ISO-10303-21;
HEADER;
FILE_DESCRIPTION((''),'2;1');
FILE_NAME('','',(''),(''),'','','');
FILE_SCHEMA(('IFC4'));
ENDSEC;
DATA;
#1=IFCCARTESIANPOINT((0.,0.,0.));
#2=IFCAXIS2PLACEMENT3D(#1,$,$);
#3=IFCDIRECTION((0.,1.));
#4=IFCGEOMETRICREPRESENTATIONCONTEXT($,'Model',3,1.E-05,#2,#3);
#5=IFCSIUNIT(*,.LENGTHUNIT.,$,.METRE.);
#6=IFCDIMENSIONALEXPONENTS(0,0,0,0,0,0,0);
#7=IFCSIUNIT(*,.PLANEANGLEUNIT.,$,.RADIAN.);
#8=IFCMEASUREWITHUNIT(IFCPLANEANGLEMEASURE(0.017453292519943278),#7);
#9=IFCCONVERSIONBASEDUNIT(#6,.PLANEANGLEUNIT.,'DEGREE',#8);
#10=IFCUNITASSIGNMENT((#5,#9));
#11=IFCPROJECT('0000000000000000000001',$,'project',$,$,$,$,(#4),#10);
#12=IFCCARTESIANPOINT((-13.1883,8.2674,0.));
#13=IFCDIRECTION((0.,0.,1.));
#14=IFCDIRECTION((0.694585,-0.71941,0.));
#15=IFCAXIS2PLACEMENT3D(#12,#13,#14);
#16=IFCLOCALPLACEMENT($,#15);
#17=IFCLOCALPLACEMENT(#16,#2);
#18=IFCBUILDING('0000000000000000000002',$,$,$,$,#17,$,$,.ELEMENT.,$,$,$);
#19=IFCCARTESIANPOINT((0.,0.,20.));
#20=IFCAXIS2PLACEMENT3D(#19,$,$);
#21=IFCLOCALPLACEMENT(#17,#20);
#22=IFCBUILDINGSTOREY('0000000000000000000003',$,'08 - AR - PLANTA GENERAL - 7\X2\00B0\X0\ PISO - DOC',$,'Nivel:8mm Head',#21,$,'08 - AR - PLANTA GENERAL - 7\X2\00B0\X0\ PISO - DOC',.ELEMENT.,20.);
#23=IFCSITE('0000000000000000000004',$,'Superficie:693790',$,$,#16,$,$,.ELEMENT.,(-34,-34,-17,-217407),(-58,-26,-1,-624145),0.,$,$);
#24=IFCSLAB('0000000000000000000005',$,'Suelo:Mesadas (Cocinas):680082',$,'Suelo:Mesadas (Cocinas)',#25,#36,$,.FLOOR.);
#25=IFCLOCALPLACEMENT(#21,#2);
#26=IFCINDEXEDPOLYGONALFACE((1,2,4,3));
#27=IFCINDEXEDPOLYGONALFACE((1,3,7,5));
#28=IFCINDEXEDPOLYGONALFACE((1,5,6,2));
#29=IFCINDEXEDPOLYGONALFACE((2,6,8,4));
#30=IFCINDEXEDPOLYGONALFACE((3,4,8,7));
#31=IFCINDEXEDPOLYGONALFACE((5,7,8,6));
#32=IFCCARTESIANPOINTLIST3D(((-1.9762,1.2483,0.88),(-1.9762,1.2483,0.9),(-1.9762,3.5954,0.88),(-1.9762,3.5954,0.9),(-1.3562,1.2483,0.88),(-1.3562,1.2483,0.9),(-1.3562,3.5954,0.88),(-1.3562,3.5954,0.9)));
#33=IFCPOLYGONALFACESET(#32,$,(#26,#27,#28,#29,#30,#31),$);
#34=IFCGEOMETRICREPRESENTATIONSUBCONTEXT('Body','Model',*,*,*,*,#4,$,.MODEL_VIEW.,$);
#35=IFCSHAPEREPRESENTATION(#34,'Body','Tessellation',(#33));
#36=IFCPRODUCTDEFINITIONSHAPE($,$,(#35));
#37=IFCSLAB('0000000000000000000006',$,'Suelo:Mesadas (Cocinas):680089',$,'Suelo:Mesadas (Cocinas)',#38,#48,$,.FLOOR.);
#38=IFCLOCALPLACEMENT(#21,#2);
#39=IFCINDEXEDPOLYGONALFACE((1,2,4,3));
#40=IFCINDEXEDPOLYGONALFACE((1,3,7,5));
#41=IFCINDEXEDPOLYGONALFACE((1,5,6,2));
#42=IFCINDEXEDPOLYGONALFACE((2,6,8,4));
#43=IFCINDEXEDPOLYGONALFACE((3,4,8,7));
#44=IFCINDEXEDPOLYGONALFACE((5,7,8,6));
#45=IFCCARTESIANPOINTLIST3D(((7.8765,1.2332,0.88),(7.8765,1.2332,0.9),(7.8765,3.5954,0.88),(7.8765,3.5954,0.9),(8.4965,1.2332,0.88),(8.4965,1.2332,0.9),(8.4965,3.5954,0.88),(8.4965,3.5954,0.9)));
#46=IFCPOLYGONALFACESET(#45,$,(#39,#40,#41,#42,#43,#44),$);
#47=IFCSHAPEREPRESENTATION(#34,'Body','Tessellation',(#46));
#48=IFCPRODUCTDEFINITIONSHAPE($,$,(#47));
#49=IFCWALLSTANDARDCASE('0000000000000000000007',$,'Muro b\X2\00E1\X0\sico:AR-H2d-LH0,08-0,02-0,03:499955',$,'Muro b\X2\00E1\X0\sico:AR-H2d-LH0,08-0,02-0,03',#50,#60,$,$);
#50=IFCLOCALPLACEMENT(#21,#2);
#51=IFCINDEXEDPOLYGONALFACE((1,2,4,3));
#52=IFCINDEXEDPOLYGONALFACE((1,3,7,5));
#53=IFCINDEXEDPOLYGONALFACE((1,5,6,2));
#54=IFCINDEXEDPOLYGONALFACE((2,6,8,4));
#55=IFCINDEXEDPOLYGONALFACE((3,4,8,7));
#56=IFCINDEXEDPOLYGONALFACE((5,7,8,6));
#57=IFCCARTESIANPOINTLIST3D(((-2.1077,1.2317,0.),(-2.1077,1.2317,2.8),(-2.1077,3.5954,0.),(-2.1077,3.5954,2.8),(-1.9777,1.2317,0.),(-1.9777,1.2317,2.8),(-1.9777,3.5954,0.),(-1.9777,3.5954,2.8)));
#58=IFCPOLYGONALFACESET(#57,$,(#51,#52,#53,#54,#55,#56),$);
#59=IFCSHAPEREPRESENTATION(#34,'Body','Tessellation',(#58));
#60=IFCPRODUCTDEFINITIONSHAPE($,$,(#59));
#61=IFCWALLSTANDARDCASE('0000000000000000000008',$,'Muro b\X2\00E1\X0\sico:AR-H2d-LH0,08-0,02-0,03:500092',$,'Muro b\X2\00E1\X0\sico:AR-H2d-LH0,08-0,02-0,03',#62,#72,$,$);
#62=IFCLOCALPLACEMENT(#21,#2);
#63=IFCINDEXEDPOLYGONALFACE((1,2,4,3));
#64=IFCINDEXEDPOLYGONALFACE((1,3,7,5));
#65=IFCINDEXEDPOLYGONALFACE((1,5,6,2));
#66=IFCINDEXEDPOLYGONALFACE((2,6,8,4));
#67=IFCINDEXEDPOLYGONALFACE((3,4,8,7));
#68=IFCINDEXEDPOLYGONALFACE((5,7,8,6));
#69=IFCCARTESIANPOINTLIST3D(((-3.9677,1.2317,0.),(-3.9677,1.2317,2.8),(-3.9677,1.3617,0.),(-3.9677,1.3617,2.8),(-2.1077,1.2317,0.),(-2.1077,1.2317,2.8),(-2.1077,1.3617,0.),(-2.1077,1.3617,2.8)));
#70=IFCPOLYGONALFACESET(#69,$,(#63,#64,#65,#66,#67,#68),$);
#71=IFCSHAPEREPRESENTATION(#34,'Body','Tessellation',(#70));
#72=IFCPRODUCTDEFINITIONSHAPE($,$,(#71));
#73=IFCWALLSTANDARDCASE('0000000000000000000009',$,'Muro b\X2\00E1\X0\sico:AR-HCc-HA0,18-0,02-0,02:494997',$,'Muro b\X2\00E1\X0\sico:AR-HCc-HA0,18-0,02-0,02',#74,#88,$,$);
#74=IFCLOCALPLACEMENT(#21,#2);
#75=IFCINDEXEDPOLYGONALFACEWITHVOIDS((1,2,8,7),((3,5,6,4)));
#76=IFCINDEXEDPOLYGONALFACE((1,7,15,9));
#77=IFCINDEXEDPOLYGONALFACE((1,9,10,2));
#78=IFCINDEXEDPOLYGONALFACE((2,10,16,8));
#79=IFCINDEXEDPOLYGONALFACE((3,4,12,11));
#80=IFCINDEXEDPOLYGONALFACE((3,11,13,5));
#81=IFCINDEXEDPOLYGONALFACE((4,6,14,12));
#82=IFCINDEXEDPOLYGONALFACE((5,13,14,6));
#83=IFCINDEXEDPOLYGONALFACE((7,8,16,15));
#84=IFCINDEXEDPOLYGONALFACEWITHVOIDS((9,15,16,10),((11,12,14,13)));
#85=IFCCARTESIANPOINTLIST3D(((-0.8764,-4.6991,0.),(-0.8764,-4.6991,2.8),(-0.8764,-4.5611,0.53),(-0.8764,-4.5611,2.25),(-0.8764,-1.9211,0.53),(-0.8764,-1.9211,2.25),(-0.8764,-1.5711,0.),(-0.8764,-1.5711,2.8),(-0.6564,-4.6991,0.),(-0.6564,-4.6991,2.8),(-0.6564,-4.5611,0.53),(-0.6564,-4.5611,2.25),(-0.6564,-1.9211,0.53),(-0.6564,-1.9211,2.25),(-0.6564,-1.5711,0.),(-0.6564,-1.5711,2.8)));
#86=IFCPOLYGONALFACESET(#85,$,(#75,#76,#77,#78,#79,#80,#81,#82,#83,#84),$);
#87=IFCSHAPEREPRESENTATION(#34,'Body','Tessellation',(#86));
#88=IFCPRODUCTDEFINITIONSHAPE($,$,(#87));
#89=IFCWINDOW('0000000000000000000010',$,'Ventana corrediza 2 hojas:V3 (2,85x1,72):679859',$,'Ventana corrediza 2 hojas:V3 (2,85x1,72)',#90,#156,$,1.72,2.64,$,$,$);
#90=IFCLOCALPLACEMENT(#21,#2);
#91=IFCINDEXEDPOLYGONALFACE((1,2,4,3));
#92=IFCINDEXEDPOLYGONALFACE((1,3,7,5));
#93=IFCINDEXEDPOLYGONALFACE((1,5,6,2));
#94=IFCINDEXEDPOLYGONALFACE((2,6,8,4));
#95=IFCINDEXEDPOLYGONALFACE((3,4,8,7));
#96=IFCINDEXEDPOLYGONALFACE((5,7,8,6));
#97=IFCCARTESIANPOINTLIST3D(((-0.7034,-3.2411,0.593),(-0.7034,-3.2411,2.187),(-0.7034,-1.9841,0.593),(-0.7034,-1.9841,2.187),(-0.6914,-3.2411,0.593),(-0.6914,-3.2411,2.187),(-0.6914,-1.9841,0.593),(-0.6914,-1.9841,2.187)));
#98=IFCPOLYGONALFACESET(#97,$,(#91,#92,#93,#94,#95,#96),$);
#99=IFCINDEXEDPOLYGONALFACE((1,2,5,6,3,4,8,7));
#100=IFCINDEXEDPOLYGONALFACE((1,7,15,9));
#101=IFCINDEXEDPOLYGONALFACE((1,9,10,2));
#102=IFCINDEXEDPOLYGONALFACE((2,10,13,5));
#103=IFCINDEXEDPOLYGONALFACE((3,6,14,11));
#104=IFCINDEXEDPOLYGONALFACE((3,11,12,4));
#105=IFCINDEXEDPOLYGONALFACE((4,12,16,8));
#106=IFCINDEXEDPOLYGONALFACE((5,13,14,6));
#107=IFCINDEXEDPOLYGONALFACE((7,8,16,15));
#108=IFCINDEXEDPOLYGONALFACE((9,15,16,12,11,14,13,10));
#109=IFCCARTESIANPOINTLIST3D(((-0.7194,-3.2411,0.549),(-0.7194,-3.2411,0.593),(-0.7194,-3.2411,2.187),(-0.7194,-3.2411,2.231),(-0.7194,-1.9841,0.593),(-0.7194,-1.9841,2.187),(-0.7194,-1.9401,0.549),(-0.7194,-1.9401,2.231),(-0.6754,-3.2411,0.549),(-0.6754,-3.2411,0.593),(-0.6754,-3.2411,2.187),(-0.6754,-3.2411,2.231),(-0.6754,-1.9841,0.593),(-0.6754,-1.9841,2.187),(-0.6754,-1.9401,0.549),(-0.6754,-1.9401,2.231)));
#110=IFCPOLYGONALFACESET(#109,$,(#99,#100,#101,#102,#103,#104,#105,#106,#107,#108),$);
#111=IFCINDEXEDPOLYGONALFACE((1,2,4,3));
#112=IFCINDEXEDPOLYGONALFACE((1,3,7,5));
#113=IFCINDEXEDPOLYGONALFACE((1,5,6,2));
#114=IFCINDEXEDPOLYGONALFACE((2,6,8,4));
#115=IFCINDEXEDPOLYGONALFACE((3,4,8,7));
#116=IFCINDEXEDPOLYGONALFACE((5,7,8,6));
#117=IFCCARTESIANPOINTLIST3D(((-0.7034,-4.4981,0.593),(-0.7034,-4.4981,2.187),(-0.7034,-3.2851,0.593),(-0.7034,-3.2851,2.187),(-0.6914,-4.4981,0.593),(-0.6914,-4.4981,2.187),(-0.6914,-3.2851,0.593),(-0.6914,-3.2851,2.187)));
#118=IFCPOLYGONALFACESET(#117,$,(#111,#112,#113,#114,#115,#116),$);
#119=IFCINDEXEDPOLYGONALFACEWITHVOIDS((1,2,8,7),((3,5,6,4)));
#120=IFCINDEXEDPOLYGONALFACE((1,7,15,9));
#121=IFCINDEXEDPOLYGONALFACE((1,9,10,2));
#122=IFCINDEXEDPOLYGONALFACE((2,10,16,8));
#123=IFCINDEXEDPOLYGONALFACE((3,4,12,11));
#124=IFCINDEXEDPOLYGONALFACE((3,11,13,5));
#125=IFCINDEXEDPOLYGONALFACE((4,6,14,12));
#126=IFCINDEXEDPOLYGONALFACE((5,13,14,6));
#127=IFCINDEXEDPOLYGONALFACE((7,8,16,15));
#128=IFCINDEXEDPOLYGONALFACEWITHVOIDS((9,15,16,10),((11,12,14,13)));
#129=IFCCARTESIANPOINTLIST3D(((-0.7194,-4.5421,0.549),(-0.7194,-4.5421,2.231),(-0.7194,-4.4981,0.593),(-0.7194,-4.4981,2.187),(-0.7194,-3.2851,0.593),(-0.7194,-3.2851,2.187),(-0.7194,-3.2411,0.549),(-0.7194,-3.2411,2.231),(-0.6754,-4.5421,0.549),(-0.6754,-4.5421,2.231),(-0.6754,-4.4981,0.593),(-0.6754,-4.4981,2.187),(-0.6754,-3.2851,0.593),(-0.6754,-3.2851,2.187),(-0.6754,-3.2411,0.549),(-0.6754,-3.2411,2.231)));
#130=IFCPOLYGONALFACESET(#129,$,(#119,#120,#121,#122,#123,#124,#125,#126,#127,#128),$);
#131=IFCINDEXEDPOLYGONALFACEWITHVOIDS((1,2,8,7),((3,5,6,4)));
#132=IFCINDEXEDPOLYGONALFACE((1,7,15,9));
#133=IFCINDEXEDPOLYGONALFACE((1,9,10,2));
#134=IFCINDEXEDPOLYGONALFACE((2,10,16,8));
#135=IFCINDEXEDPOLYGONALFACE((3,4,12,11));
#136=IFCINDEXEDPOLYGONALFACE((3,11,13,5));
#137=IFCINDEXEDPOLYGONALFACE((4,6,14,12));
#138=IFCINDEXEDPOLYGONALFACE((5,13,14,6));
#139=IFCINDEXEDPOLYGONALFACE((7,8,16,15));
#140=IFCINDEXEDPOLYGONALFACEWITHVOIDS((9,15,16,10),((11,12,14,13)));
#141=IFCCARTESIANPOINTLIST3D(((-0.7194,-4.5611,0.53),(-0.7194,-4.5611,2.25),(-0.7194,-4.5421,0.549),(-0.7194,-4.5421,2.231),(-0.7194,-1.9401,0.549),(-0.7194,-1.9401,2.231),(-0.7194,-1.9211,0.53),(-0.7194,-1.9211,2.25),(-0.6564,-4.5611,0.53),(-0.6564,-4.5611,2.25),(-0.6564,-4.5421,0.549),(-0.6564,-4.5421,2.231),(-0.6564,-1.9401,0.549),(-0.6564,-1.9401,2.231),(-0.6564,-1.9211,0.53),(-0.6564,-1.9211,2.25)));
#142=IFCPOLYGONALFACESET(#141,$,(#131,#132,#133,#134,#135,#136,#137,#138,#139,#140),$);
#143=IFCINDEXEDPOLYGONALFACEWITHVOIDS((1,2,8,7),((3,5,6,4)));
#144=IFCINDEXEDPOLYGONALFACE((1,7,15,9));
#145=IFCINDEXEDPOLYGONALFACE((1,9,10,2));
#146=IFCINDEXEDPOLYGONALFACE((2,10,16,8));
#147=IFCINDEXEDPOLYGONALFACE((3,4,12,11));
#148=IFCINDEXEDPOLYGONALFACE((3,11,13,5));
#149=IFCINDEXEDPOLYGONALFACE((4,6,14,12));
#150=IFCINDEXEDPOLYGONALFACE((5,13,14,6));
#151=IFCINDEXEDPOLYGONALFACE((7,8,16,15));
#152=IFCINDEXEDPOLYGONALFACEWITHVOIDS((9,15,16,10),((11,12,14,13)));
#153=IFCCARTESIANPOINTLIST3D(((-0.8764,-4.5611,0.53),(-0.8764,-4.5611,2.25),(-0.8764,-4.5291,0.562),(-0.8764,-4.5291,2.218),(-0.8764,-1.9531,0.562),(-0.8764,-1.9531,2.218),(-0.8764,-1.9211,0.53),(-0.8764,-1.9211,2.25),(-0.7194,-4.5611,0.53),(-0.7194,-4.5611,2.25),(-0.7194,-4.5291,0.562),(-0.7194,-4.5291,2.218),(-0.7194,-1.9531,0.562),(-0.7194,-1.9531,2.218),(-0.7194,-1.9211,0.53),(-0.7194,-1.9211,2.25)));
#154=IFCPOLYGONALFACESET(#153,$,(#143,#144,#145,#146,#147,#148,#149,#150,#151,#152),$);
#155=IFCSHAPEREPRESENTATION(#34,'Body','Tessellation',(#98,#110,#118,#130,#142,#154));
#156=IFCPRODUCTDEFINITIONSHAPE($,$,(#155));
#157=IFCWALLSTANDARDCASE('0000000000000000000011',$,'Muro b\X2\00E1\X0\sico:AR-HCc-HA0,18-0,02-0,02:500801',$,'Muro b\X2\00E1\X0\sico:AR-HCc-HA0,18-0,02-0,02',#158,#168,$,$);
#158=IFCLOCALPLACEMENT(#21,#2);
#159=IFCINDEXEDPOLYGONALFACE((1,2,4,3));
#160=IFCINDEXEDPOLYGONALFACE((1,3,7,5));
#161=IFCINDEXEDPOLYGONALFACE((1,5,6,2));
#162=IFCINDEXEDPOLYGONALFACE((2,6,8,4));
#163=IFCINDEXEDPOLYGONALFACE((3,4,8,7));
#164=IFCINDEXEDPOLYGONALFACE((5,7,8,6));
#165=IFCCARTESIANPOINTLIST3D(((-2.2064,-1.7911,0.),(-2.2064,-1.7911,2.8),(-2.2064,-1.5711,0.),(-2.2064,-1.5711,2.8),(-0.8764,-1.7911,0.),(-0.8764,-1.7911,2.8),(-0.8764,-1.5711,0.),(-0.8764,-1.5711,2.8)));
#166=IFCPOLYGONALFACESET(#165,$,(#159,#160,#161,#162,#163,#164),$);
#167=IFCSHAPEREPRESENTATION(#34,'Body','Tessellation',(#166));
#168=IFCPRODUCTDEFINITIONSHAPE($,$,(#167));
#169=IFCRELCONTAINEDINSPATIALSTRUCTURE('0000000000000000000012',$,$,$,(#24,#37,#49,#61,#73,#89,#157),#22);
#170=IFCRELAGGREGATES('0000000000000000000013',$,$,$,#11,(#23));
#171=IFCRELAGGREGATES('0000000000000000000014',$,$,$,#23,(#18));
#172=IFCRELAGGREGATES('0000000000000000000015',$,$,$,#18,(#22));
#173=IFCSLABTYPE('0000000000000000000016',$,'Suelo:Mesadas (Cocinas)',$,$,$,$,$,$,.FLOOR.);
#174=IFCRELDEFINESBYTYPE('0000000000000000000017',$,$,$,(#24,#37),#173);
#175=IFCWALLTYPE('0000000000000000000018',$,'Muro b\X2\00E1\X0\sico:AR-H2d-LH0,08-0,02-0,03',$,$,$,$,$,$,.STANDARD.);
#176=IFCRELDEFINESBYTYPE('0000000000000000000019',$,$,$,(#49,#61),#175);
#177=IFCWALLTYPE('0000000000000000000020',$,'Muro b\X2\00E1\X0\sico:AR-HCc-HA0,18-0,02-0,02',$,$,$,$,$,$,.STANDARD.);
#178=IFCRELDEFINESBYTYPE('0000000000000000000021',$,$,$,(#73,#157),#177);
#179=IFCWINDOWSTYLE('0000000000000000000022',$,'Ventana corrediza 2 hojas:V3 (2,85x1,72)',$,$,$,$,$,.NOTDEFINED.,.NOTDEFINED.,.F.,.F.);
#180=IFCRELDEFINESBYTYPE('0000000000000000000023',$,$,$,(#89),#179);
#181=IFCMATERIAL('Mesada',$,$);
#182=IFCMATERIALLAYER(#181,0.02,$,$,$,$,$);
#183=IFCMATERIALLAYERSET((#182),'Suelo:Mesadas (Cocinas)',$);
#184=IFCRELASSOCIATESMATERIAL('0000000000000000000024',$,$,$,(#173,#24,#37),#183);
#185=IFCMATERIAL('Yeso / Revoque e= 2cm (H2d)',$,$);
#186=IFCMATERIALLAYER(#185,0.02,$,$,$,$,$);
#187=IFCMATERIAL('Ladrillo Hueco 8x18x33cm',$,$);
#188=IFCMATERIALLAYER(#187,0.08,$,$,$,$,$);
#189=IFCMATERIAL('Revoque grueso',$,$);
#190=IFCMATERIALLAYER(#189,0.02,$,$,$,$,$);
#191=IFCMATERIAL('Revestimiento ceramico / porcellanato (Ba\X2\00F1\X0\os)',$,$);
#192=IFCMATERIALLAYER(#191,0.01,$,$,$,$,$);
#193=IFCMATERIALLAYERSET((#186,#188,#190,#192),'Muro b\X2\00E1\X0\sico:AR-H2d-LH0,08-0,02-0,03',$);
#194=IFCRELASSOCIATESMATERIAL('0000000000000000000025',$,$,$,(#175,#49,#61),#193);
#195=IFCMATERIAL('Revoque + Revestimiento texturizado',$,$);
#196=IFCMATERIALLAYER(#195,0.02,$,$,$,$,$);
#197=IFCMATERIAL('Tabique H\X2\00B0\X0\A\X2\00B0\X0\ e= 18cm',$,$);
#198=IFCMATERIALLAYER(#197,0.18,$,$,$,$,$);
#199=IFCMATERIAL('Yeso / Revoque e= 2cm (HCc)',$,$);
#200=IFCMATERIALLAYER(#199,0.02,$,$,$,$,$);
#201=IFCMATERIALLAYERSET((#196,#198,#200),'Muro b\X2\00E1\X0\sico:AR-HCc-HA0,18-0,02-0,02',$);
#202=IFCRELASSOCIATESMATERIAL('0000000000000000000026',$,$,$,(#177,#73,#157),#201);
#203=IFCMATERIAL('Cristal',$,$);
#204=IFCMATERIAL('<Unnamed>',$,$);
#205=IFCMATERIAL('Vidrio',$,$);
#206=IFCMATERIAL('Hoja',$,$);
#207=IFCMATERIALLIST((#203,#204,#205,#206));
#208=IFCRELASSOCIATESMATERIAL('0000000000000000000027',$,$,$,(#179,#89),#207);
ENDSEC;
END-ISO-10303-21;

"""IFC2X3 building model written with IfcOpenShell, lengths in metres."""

from ifc_helpers import new_model, entity, si_unit, converted_unit, direction, frame, frame_2d, origin, origin_2d_with_axis, place, context, subcontext, project, spatial, polyline, rectangle, outline, extrude, source, transform, mapped, material, material_list, layer, layer_set, layer_usage, type_object, type_shapes, element, fill, save


model = new_model("IFC2X3")

# Units and contexts
model_context = context("Model", 3, precision=1e-05, world=origin(), true_north=direction((0.0, 1.0)))
body_context = subcontext(model_context, "Body", "Model", "MODEL_VIEW")
ifc_project = project(units=[si_unit("LENGTHUNIT", "METRE"), converted_unit("PLANEANGLEUNIT", "DEGREE", entity("IfcPlaneAngleMeasure", 0.017453292519943278), si_unit("PLANEANGLEUNIT", "RADIAN"), dimensions=[0, 0, 0, 0, 0, 0, 0])], contexts=[model_context])

# Site, building, storey
site_placement = place(None, frame((-13.1883, 8.2674, 0.0), z_axis=(0.0, 0.0, 1.0), x_axis=(0.694585, -0.71941, 0.0)))
site = spatial("IfcSite", under=ifc_project, at=site_placement, Name="Superficie:693790", CompositionType="ELEMENT", RefLatitude=(-34, -34, -17, -217407), RefLongitude=(-58, -26, -1, -624145), RefElevation=0.0)
building_placement = place(site_placement, origin())
building = spatial("IfcBuilding", under=site, at=building_placement, CompositionType="ELEMENT")
storey_placement = place(building_placement, frame((0.0, 0.0, 20.0)))
storey = spatial("IfcBuildingStorey", under=building, at=storey_placement, Name="08 - AR - PLANTA GENERAL - 7° PISO - DOC", ObjectType="Nivel:8mm Head", LongName="08 - AR - PLANTA GENERAL - 7° PISO - DOC", CompositionType="ELEMENT", Elevation=20.0)

# Slabs
ifc_material_1 = material(Name="Mesada")
ifc_layer_1 = layer(ifc_material_1, 0.02)
ifc_layer_set_1 = layer_set([ifc_layer_1], Name="Suelo:Mesadas (Cocinas)")
ifc_layer_usage_1 = layer_usage(ifc_layer_set_1, "AXIS3", "POSITIVE", 0.0)
slab_type = type_object("IfcSlabType", Name="Suelo:Mesadas (Cocinas)", PredefinedType="FLOOR", material=ifc_layer_set_1)
slab_1_placement = place(storey_placement, origin())
element("IfcSlab", 1, at=slab_1_placement, inside=storey, type_object=slab_type, material=ifc_layer_usage_1, Name="Suelo:Mesadas (Cocinas):680082", ObjectType="Suelo:Mesadas (Cocinas)", PredefinedType="FLOOR", context=body_context, shape_type="SweptSolid", body=[
    extrude(rectangle(XDim=2.3472, YDim=0.62, at=origin_2d_with_axis()), frame((-1.6662, 2.4219, 0.9), z_axis=(0.0, 0.0, -1.0), x_axis=(0.0, 1.0, 0.0)), (0.0, 0.0, 1.0), 0.02),
])
ifc_layer_usage_2 = layer_usage(ifc_layer_set_1, "AXIS3", "POSITIVE", 0.0)
slab_2_placement = place(storey_placement, origin())
element("IfcSlab", 2, at=slab_2_placement, inside=storey, type_object=slab_type, material=ifc_layer_usage_2, Name="Suelo:Mesadas (Cocinas):680089", ObjectType="Suelo:Mesadas (Cocinas)", PredefinedType="FLOOR", context=body_context, shape_type="SweptSolid", body=[
    extrude(rectangle(XDim=2.3623, YDim=0.62, at=frame_2d((0.0, 0.0), x_axis=(1.0, 0.0))), frame((8.1865, 2.4143, 0.9), z_axis=(0.0, 0.0, -1.0), x_axis=(0.0, 1.0, 0.0)), (0.0, 0.0, 1.0), 0.02),
])

# Walls
ifc_material_2 = material(Name="Yeso / Revoque e= 2cm (H2d)")
ifc_layer_2 = layer(ifc_material_2, 0.02)
ifc_material_3 = material(Name="Ladrillo Hueco 8x18x33cm")
ifc_layer_3 = layer(ifc_material_3, 0.08)
ifc_material_4 = material(Name="Revoque grueso")
ifc_layer_4 = layer(ifc_material_4, 0.02)
ifc_material_5 = material(Name="Revestimiento ceramico / porcellanato (Baños)")
ifc_layer_5 = layer(ifc_material_5, 0.01)
ifc_layer_set_2 = layer_set([ifc_layer_2, ifc_layer_3, ifc_layer_4, ifc_layer_5], Name="Muro básico:AR-H2d-LH0,08-0,02-0,03")
ifc_layer_usage_3 = layer_usage(ifc_layer_set_2, "AXIS2", "POSITIVE", -0.065)
wall_type_1 = type_object("IfcWallType", Name="Muro básico:AR-H2d-LH0,08-0,02-0,03", PredefinedType="STANDARD", material=ifc_layer_set_2)
wall_1_placement = place(storey_placement, frame((-2.0427, 1.2317, 0.0), z_axis=(0.0, 0.0, 1.0), x_axis=(0.0, 1.0, 0.0)))
element("IfcWallStandardCase", 3, at=wall_1_placement, inside=storey, type_object=wall_type_1, material=ifc_layer_usage_3, Name="Muro básico:AR-H2d-LH0,08-0,02-0,03:499955", ObjectType="Muro básico:AR-H2d-LH0,08-0,02-0,03", context=body_context, shape_type="SweptSolid", body=[
    extrude(rectangle(XDim=2.3637, YDim=0.13, at=frame_2d((1.1819, 0.0), x_axis=(-1.0, 0.0))), origin(), (0.0, 0.0, 1.0), 2.8),
])
ifc_layer_usage_4 = layer_usage(ifc_layer_set_2, "AXIS2", "NEGATIVE", 0.065)
wall_2_placement = place(storey_placement, frame((-2.1077, 1.2967, 0.0), z_axis=(0.0, 0.0, 1.0), x_axis=(-1.0, 0.0, 0.0)))
element("IfcWallStandardCase", 4, at=wall_2_placement, inside=storey, type_object=wall_type_1, material=ifc_layer_usage_4, Name="Muro básico:AR-H2d-LH0,08-0,02-0,03:500092", ObjectType="Muro básico:AR-H2d-LH0,08-0,02-0,03", context=body_context, shape_type="SweptSolid", body=[
    extrude(rectangle(XDim=1.86, YDim=0.13, at=frame_2d((0.93, 0.0), x_axis=(-1.0, 0.0))), origin(), (0.0, 0.0, 1.0), 2.8),
])

# Wall, opening, window
ifc_material_6 = material(Name="Revoque + Revestimiento texturizado")
ifc_layer_6 = layer(ifc_material_6, 0.02)
ifc_material_7 = material(Name="Tabique H°A° e= 18cm")
ifc_layer_7 = layer(ifc_material_7, 0.18)
ifc_material_8 = material(Name="Yeso / Revoque e= 2cm (HCc)")
ifc_layer_8 = layer(ifc_material_8, 0.02)
ifc_layer_set_3 = layer_set([ifc_layer_6, ifc_layer_7, ifc_layer_8], Name="Muro básico:AR-HCc-HA0,18-0,02-0,02")
ifc_layer_usage_5 = layer_usage(ifc_layer_set_3, "AXIS2", "NEGATIVE", 0.11)
wall_type_2 = type_object("IfcWallType", Name="Muro básico:AR-HCc-HA0,18-0,02-0,02", PredefinedType="STANDARD", material=ifc_layer_set_3)
wall_3_placement = place(storey_placement, frame((-0.7664, -1.5711, 0.0), z_axis=(0.0, 0.0, 1.0), x_axis=(0.0, -1.0, 0.0)))
wall_3 = element("IfcWallStandardCase", 5, at=wall_3_placement, inside=storey, type_object=wall_type_2, material=ifc_layer_usage_5, Name="Muro básico:AR-HCc-HA0,18-0,02-0,02:494997", ObjectType="Muro básico:AR-HCc-HA0,18-0,02-0,02", context=body_context, shape_type="SweptSolid", body=[
    extrude(rectangle(XDim=3.128, YDim=0.22, at=frame_2d((1.564, 0.0), x_axis=(-1.0, 0.0))), origin(), (0.0, 0.0, 1.0), 2.8),
])
opening_1_placement = place(wall_3_placement, frame((0.35, -0.11, 0.53)))
opening_1 = element("IfcOpeningElement", 6, at=opening_1_placement, cuts=wall_3, ObjectType="Opening", context=body_context, shape_type="SweptSolid", body=[
    extrude(rectangle(XDim=1.72, YDim=2.64, at=frame_2d((0.86, 1.32), x_axis=(1.0, 0.0))), frame((0.0, 0.0, 0.0), z_axis=(0.0, 1.0, 0.0), x_axis=(0.0, 0.0, 1.0)), (0.0, 0.0, 1.0), 0.22),
])
ifc_material_9 = material(Name="Cristal")
ifc_material_10 = material(Name="<Unnamed>")
ifc_material_11 = material(Name="Vidrio")
ifc_material_12 = material(Name="Hoja")
ifc_material_list_1 = material_list([ifc_material_9, ifc_material_10, ifc_material_11, ifc_material_12])
window_style = type_object("IfcWindowStyle", Name="Ventana corrediza 2 hojas:V3 (2,85x1,72)", ConstructionType="NOTDEFINED", OperationType="NOTDEFINED", ParameterTakesPrecedence=False, Sizeable=False, material=ifc_material_list_1)
shared_shape_1 = source(origin(), body_context, "Body", "SweptSolid", [
    extrude(rectangle(XDim=0.012, YDim=1.257, at=frame_2d((0.0, 0.0), x_axis=(1.0, 0.0))), frame((0.6915, 0.179, 0.063), z_axis=(0.0, 0.0, 1.0), x_axis=(0.0, -1.0, 0.0)), (0.0, 0.0, 1.0), 1.594),
    extrude(outline(polyline([(-0.6615, -0.841), (0.6395, -0.841), (0.6395, -0.797), (-0.6175, -0.797), (-0.6175, 0.797), (0.6395, 0.797), (0.6395, 0.841), (-0.6615, 0.841), (-0.6615, -0.841)])), frame((0.6805, 0.157, 0.86), z_axis=(0.0, 1.0, 0.0), x_axis=(1.0, 0.0, 0.0)), (0.0, 0.0, 1.0), 0.044),
    extrude(rectangle(XDim=0.012, YDim=1.213, at=frame_2d((0.0, 0.0), x_axis=(1.0, 0.0))), frame((1.9705, 0.179, 0.063), z_axis=(0.0, 0.0, 1.0), x_axis=(0.0, -1.0, 0.0)), (0.0, 0.0, 1.0), 1.594),
    extrude(outline(polyline([(-0.6505, -0.841), (0.6505, -0.841), (0.6505, 0.841), (-0.6505, 0.841), (-0.6505, -0.841)]), holes=[polyline([(-0.6065, -0.797), (-0.6065, 0.797), (0.6065, 0.797), (0.6065, -0.797), (-0.6065, -0.797)])]), frame((1.9705, 0.157, 0.86), z_axis=(0.0, 1.0, 0.0), x_axis=(1.0, 0.0, 0.0)), (0.0, 0.0, 1.0), 0.044),
    extrude(outline(polyline([(-1.32, -0.86), (1.32, -0.86), (1.32, 0.86), (-1.32, 0.86), (-1.32, -0.86)]), holes=[polyline([(-1.301, -0.841), (-1.301, 0.841), (1.301, 0.841), (1.301, -0.841), (-1.301, -0.841)])]), frame((1.32, 0.157, 0.86), z_axis=(0.0, 1.0, 0.0), x_axis=(1.0, 0.0, 0.0)), (0.0, 0.0, 1.0), 0.063),
    extrude(outline(polyline([(-1.32, -0.86), (1.32, -0.86), (1.32, 0.86), (-1.32, 0.86), (-1.32, -0.86)]), holes=[polyline([(-1.288, -0.828), (-1.288, 0.828), (1.288, 0.828), (1.288, -0.828), (-1.288, -0.828)])]), frame((1.32, 0.0, 0.86), z_axis=(0.0, 1.0, 0.0), x_axis=(1.0, 0.0, 0.0)), (0.0, 0.0, 1.0), 0.157),
])
type_shapes(window_style, [shared_shape_1])
window_placement = place(opening_1_placement, origin())
window = element("IfcWindow", 7, at=window_placement, inside=storey, type_object=window_style, material=ifc_material_list_1, Name="Ventana corrediza 2 hojas:V3 (2,85x1,72):679859", ObjectType="Ventana corrediza 2 hojas:V3 (2,85x1,72)", OverallHeight=1.72, OverallWidth=2.64, context=body_context, shape_type="MappedRepresentation", body=[
    mapped(shared_shape_1, transform((0.0, 0.0, 0.0), scale=1.0)),
])
fill(opening_1, window)

# Wall
ifc_layer_usage_6 = layer_usage(ifc_layer_set_3, "AXIS2", "NEGATIVE", 0.11)
wall_4_placement = place(storey_placement, frame((-2.2064, -1.6811, 0.0)))
element("IfcWallStandardCase", 8, at=wall_4_placement, inside=storey, type_object=wall_type_2, material=ifc_layer_usage_6, Name="Muro básico:AR-HCc-HA0,18-0,02-0,02:500801", ObjectType="Muro básico:AR-HCc-HA0,18-0,02-0,02", context=body_context, shape_type="SweptSolid", body=[
    extrude(rectangle(XDim=1.33, YDim=0.22, at=frame_2d((0.665, 0.0), x_axis=(-1.0, 0.0))), origin(), (0.0, 0.0, 1.0), 2.8),
])

save(model, "model.ifc")
